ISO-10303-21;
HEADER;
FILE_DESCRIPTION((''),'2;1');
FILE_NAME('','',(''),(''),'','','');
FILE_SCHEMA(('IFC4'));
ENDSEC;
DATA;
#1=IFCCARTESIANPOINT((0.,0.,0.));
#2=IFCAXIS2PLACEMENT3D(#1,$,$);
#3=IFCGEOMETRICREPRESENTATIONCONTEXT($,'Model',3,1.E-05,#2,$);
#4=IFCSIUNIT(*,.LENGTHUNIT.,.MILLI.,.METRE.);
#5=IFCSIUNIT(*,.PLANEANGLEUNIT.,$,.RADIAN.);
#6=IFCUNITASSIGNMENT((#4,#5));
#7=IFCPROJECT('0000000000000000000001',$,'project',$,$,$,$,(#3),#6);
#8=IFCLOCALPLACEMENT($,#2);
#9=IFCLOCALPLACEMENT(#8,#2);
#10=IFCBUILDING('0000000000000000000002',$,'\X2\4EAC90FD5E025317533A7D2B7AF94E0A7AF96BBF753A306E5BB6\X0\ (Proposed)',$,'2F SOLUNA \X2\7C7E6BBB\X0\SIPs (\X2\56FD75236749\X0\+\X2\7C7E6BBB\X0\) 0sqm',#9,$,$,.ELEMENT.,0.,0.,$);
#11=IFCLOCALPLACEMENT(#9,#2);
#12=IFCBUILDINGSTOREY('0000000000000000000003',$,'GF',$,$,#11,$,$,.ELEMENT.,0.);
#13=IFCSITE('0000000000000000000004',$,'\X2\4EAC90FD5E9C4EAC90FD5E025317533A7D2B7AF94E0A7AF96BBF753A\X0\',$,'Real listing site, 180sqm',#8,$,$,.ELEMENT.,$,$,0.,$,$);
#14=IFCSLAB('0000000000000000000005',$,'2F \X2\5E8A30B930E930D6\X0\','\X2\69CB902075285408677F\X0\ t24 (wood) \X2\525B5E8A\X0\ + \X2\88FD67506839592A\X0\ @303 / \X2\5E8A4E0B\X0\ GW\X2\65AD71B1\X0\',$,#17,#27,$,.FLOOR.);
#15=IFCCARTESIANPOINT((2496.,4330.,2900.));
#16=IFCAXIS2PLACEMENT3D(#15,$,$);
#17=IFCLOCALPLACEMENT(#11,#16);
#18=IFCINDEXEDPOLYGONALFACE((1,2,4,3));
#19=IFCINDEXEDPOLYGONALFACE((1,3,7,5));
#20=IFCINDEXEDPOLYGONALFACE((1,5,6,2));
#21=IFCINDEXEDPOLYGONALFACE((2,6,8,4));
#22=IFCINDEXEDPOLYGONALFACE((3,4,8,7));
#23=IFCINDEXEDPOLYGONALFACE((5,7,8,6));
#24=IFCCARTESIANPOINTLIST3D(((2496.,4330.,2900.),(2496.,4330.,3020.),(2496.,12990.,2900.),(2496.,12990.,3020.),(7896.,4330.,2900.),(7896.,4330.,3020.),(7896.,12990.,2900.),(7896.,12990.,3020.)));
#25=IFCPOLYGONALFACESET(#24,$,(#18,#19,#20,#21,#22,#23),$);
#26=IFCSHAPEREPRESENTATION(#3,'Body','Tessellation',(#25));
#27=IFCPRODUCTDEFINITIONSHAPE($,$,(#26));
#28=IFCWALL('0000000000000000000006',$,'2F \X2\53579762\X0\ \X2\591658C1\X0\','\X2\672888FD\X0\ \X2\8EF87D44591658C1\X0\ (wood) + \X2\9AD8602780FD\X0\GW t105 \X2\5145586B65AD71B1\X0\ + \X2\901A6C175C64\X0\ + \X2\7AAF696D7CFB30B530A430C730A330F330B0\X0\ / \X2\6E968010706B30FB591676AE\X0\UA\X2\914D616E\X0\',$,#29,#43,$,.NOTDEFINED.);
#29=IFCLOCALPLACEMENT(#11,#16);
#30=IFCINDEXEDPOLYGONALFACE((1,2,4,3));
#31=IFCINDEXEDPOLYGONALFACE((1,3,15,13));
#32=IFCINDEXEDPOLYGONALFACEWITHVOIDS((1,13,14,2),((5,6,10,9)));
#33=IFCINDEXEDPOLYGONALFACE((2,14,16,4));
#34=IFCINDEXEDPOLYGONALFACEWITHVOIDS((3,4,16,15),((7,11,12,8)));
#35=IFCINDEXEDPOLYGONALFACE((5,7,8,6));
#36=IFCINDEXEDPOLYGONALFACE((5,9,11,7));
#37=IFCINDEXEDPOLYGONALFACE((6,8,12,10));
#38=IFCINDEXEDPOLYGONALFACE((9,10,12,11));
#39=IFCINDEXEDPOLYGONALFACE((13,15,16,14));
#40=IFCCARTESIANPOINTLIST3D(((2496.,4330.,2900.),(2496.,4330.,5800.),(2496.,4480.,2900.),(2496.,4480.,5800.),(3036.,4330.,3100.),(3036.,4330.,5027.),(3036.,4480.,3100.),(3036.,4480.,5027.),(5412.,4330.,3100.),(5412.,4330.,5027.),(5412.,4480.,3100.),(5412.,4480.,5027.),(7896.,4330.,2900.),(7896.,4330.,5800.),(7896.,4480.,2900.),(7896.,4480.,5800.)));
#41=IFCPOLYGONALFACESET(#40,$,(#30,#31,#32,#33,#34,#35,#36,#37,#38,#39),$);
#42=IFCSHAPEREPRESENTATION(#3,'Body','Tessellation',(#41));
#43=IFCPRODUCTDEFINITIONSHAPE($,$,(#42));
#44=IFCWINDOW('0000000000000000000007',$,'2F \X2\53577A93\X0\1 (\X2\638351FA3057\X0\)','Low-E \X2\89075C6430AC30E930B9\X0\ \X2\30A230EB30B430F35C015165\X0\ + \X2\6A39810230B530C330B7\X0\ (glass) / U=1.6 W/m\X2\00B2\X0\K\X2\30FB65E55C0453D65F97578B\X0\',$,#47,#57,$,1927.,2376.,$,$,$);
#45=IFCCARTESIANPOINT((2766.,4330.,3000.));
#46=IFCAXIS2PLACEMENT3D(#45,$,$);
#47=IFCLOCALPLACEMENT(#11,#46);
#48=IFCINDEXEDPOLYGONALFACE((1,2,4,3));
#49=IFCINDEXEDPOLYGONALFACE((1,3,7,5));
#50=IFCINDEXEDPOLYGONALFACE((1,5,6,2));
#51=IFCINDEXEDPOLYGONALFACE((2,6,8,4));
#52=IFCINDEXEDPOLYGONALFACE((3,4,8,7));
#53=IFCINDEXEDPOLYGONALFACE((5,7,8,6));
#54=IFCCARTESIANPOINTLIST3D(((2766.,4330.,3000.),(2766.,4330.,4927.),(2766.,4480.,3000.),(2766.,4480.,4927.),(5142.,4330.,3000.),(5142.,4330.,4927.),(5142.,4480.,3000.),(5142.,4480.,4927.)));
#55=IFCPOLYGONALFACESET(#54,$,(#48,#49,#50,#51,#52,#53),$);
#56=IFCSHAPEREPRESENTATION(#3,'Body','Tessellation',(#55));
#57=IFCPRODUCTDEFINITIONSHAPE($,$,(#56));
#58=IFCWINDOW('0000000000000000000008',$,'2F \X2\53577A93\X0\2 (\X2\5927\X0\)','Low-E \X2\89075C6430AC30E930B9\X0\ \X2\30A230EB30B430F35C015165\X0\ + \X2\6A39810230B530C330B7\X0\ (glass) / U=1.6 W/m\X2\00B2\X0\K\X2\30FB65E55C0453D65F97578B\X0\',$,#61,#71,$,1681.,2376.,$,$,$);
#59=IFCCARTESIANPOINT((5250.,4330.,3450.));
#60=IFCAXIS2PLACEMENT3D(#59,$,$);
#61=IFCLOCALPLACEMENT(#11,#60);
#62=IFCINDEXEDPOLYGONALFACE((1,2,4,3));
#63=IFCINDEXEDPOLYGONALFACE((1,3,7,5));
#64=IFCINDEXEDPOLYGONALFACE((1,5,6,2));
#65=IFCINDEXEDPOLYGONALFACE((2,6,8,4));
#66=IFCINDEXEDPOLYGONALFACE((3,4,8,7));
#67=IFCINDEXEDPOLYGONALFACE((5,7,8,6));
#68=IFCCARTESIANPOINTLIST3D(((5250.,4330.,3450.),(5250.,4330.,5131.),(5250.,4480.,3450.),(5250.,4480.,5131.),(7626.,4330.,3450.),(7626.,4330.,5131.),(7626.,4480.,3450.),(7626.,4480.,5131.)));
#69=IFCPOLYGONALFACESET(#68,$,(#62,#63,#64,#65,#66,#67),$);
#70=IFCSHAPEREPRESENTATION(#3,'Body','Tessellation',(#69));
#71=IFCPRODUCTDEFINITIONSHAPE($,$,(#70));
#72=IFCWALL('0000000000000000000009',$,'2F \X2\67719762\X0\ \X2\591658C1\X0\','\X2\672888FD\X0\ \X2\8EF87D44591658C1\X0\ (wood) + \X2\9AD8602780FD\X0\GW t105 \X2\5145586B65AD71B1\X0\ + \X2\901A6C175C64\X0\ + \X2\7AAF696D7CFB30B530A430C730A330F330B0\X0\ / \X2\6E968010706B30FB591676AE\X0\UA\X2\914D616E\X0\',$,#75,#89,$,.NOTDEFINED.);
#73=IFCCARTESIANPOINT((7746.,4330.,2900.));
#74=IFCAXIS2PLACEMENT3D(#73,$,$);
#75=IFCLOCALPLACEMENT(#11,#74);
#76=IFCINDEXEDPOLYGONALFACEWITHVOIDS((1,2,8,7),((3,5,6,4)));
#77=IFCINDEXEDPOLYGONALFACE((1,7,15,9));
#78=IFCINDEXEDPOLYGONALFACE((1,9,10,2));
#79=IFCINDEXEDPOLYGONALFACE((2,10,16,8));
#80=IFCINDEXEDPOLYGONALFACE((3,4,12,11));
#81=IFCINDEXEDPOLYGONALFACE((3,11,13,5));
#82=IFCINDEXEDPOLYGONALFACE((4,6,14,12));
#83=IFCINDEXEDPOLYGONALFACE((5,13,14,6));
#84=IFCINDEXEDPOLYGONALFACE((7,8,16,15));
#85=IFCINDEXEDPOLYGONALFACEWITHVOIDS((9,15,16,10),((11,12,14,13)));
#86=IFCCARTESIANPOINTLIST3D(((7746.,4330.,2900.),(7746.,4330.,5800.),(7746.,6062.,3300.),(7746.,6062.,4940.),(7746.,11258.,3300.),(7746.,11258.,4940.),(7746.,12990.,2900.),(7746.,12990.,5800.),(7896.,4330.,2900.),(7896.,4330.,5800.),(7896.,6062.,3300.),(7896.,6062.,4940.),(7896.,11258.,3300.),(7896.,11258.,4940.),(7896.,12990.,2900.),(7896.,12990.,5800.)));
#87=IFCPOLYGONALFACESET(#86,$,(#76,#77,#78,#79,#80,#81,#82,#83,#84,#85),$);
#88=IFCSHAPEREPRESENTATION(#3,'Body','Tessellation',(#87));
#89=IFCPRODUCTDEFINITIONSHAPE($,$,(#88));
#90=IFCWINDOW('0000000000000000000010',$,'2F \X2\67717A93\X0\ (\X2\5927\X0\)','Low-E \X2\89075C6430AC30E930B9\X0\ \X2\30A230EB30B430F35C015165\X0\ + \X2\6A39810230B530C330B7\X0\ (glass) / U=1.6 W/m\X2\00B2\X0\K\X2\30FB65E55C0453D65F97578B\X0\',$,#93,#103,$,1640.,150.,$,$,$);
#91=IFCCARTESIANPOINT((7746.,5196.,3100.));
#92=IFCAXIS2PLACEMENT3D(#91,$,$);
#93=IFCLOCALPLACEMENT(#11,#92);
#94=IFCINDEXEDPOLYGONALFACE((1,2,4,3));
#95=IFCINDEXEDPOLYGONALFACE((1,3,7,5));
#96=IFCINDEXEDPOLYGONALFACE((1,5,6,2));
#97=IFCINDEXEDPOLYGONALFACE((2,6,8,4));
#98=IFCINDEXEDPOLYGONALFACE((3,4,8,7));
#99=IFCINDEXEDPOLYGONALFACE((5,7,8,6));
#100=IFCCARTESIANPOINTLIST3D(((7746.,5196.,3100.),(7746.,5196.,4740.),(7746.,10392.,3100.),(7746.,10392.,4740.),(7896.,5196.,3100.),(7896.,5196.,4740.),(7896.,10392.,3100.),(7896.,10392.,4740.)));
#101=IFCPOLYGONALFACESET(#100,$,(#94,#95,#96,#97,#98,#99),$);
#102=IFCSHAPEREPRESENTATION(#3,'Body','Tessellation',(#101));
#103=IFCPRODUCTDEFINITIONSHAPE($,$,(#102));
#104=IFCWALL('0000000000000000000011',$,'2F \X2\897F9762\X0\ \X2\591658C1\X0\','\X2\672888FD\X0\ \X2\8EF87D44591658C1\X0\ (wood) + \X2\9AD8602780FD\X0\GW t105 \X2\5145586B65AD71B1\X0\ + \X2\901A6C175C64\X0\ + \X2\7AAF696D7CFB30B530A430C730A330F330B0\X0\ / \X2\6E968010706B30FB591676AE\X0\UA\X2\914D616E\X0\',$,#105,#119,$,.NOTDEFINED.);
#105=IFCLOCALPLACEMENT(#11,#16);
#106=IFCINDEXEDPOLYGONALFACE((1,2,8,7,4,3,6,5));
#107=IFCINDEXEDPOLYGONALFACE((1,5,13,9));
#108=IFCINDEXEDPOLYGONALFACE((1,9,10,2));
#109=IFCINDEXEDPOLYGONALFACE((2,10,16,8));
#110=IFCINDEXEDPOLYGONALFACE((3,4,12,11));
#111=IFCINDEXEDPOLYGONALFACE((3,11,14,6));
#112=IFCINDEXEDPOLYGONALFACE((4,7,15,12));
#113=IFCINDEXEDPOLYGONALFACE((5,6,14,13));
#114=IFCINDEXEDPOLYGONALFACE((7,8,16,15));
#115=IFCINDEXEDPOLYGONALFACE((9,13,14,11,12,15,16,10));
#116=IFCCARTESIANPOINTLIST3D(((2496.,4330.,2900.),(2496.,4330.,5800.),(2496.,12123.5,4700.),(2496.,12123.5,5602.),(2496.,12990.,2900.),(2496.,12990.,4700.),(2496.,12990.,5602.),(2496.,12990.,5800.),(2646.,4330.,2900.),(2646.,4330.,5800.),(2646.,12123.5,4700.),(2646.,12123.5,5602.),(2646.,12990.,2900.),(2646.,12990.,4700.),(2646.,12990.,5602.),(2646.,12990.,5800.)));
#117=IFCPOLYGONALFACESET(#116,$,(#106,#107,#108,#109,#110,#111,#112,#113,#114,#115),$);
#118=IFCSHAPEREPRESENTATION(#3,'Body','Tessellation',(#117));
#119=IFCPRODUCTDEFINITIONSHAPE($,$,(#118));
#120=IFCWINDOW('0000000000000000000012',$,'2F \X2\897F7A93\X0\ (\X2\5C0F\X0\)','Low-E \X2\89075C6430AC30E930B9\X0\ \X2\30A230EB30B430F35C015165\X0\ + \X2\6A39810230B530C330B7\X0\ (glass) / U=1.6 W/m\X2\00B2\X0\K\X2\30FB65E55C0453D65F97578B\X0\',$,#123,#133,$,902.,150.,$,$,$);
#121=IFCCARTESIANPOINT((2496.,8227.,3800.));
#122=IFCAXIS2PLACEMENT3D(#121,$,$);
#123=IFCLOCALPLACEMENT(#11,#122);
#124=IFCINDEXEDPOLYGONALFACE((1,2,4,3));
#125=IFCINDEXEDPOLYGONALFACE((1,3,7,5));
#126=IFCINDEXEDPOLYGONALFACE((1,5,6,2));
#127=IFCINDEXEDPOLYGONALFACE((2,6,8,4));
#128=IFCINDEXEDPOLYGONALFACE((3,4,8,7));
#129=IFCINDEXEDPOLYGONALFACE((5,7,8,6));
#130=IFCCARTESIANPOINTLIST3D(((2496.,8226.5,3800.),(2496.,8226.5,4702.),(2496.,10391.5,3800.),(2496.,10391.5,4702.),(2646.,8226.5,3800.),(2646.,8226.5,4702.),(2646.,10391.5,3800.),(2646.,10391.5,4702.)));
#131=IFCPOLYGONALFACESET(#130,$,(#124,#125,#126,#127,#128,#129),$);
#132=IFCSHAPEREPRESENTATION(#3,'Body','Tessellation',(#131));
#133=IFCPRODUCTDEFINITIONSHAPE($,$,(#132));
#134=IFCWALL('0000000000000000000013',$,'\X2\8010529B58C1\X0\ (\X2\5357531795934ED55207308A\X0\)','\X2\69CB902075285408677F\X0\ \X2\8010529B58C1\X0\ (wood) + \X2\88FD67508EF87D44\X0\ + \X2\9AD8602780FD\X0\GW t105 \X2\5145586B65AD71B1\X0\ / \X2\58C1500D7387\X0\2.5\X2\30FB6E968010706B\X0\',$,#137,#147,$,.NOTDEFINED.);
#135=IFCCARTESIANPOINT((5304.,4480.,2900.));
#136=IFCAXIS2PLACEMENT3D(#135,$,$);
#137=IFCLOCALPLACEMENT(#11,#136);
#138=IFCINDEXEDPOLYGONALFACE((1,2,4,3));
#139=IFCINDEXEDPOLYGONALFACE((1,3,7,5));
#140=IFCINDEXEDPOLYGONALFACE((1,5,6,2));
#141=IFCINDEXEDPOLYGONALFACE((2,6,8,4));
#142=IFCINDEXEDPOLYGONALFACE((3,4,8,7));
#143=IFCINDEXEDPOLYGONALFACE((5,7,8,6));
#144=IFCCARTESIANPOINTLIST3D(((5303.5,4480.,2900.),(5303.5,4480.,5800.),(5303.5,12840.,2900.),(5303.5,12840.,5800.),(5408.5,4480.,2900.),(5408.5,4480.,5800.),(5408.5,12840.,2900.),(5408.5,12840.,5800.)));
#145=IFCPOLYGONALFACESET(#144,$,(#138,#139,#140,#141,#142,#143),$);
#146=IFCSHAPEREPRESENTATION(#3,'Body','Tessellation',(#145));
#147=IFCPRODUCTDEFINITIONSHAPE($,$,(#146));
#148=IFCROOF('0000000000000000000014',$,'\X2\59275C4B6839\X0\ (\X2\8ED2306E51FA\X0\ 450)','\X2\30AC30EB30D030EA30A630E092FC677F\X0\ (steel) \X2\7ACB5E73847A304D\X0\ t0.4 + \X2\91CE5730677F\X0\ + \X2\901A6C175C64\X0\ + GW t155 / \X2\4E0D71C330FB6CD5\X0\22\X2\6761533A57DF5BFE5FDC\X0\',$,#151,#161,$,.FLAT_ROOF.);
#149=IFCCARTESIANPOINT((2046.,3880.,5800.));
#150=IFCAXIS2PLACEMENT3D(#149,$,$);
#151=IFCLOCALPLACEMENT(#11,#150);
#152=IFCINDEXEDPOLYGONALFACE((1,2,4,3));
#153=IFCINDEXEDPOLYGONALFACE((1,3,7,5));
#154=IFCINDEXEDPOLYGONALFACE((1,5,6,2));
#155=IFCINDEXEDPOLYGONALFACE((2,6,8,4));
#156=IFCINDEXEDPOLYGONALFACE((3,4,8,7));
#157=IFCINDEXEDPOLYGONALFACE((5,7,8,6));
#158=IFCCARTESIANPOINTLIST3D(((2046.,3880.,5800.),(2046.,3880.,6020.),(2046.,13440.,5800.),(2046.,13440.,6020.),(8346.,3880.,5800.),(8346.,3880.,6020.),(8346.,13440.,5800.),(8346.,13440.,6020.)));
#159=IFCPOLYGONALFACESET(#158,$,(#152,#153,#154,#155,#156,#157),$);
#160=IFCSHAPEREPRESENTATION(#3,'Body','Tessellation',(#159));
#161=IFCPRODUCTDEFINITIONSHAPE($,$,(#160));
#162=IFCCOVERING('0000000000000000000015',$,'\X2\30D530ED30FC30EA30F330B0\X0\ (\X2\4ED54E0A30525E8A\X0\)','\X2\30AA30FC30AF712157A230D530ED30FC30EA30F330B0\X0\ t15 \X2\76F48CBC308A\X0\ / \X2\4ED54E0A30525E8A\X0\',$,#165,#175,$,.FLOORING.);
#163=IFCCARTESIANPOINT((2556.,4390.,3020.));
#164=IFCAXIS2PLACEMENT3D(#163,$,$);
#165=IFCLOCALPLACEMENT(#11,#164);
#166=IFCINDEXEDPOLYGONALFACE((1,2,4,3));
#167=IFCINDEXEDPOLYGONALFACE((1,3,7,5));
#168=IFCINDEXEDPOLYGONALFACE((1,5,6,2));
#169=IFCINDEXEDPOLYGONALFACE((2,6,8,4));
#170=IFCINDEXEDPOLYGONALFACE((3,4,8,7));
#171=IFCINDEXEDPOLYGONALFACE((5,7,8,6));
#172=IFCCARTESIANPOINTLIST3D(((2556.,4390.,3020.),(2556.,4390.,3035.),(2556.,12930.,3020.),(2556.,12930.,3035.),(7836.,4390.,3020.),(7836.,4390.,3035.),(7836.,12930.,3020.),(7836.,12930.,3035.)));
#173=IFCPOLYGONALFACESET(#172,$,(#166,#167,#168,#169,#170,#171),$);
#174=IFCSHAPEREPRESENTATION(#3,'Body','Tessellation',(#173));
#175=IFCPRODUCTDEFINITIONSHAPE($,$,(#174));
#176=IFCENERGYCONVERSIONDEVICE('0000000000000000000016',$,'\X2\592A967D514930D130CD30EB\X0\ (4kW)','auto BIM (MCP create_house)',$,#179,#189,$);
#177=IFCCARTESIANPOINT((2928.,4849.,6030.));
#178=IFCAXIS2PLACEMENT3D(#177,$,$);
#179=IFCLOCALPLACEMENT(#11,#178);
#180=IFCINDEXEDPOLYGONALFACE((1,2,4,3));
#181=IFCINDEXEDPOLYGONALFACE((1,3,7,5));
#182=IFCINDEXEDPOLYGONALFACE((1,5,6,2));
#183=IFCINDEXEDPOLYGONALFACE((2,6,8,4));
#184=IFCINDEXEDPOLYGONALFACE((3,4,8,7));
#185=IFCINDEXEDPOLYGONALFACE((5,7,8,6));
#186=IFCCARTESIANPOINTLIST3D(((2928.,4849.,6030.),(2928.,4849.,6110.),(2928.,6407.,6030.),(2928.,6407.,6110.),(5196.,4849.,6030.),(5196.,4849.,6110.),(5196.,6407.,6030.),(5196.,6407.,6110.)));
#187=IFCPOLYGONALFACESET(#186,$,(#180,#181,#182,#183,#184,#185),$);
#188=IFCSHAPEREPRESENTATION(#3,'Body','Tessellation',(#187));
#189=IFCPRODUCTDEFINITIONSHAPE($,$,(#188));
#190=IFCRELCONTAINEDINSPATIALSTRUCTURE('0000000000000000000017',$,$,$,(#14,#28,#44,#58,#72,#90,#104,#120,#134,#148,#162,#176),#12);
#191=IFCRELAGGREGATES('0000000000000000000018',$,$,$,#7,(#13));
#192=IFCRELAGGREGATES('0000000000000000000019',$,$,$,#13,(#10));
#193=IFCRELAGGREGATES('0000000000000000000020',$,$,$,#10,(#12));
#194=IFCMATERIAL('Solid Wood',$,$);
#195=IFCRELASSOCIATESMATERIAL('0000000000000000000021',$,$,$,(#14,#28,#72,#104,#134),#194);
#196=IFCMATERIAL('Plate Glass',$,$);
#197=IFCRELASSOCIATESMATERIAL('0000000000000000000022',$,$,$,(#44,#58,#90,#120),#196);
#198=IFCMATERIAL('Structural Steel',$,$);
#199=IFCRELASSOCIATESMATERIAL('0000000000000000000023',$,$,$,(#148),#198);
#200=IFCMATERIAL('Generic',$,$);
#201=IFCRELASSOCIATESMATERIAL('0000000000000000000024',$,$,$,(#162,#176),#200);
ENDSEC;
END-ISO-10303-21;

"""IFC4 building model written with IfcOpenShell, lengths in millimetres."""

from ifc_helpers import new_model, si_unit, frame, frame_2d, origin, place, context, project, spatial, rectangle, extrude, material, element, fill, save


model = new_model("IFC4")

# Units and contexts
model_context = context("Model", 3, precision=1e-05, world=origin())
ifc_project = project(units=[si_unit("LENGTHUNIT", "METRE", prefix="MILLI"), si_unit("PLANEANGLEUNIT", "RADIAN")], contexts=[model_context])

# Site, building, storey
site_placement = place(None, origin())
site = spatial("IfcSite", under=ifc_project, at=site_placement, Name="京都府京都市北区紫竹上竹殿町", ObjectType="Real listing site, 180sqm", CompositionType="ELEMENT", RefElevation=0.0)
building_placement = place(site_placement, origin())
building = spatial("IfcBuilding", under=site, at=building_placement, Name="京都市北区紫竹上竹殿町の家 (Proposed)", ObjectType="2F SOLUNA 籾殻SIPs (国産杉+籾殻) 0sqm", CompositionType="ELEMENT", ElevationOfRefHeight=0.0, ElevationOfTerrain=0.0)
storey_placement = place(building_placement, origin())
storey = spatial("IfcBuildingStorey", under=building, at=storey_placement, Name="GF", CompositionType="ELEMENT", Elevation=0.0)

# Slab
ifc_material_1 = material(Name="Solid Wood")
slab_placement = place(storey_placement, frame((2496.0, 4330.0, 2900.0)))
element("IfcSlab", 1, at=slab_placement, inside=storey, material=ifc_material_1, Name="2F 床スラブ", Description="構造用合板 t24 (wood) 剛床 + 製材根太 @303 / 床下 GW断熱", PredefinedType="FLOOR", context=model_context, shape_type="SweptSolid", body=[
    extrude(rectangle(XDim=5400.0, YDim=8660.0, at=frame_2d((2700.0, 4330.0))), frame((2496.0, 4330.0, 2900.0)), (0.0, 0.0, 1.0), 120.0),
])

# Wall, openings, windows
wall_1_placement = place(storey_placement, frame((2496.0, 4330.0, 2900.0)))
wall_1 = element("IfcWall", 2, at=wall_1_placement, inside=storey, material=ifc_material_1, Name="2F 南面 外壁", Description="木製 軸組外壁 (wood) + 高性能GW t105 充填断熱 + 通気層 + 窯業系サイディング / 準耐火・外皮UA配慮", PredefinedType="NOTDEFINED", context=model_context, shape_type="SweptSolid", body=[
    extrude(rectangle(XDim=5400.0, YDim=150.0, at=frame_2d((2700.0, 75.0))), frame((2496.0, 4330.0, 2900.0)), (0.0, 0.0, 1.0), 2900.0),
])
opening_1_placement = place(storey_placement, frame((2766.0, 4330.0, 3000.0)))
opening_1 = element("IfcOpeningElement", 3, at=opening_1_placement, cuts=wall_1, PredefinedType="NOTDEFINED", context=model_context, shape_type="SweptSolid", body=[
    extrude(rectangle(XDim=2376.0, YDim=150.0, at=frame_2d((1188.0, 75.0))), frame((2766.0, 4330.0, 3000.0)), (0.0, 0.0, 1.0), 1927.0),
])
opening_2_placement = place(storey_placement, frame((5250.0, 4330.0, 3450.0)))
opening_2 = element("IfcOpeningElement", 4, at=opening_2_placement, cuts=wall_1, PredefinedType="NOTDEFINED", context=model_context, shape_type="SweptSolid", body=[
    extrude(rectangle(XDim=2376.0, YDim=150.0, at=frame_2d((1188.0, 75.0))), frame((5250.0, 4330.0, 3450.0)), (0.0, 0.0, 1.0), 1681.0),
])
ifc_material_2 = material(Name="Plate Glass")
window_1_placement = place(storey_placement, frame((2766.0, 4330.0, 3000.0)))
window_1 = element("IfcWindow", 5, at=window_1_placement, inside=storey, material=ifc_material_2, Name="2F 南窓1 (掃出し)", Description="Low-E 複層ガラス アルゴン封入 + 樹脂サッシ (glass) / U=1.6 W/m²K・日射取得型", OverallHeight=1927.0, OverallWidth=2376.0, context=model_context, shape_type="SweptSolid", body=[
    extrude(rectangle(XDim=2376.0, YDim=150.0, at=frame_2d((1188.0, 75.0))), frame((2766.0, 4330.0, 3000.0)), (0.0, 0.0, 1.0), 1927.0),
])
fill(opening_1, window_1)
window_2_placement = place(storey_placement, frame((5250.0, 4330.0, 3450.0)))
window_2 = element("IfcWindow", 6, at=window_2_placement, inside=storey, material=ifc_material_2, Name="2F 南窓2 (大)", Description="Low-E 複層ガラス アルゴン封入 + 樹脂サッシ (glass) / U=1.6 W/m²K・日射取得型", OverallHeight=1681.0, OverallWidth=2376.0, context=model_context, shape_type="SweptSolid", body=[
    extrude(rectangle(XDim=2376.0, YDim=150.0, at=frame_2d((1188.0, 75.0))), frame((5250.0, 4330.0, 3450.0)), (0.0, 0.0, 1.0), 1681.0),
])
fill(opening_2, window_2)

# Walls, openings, windows
wall_2_placement = place(storey_placement, frame((7746.0, 4330.0, 2900.0)))
wall_2 = element("IfcWall", 7, at=wall_2_placement, inside=storey, material=ifc_material_1, Name="2F 東面 外壁", Description="木製 軸組外壁 (wood) + 高性能GW t105 充填断熱 + 通気層 + 窯業系サイディング / 準耐火・外皮UA配慮", PredefinedType="NOTDEFINED", context=model_context, shape_type="SweptSolid", body=[
    extrude(rectangle(XDim=150.0, YDim=8660.0, at=frame_2d((75.0, 4330.0))), frame((7746.0, 4330.0, 2900.0)), (0.0, 0.0, 1.0), 2900.0),
])
opening_3_placement = place(storey_placement, frame((7746.0, 5196.0, 3100.0)))
opening_3 = element("IfcOpeningElement", 8, at=opening_3_placement, cuts=wall_2, PredefinedType="NOTDEFINED", context=model_context, shape_type="SweptSolid", body=[
    extrude(rectangle(XDim=150.0, YDim=5196.0, at=frame_2d((75.0, 2598.0))), frame((7746.0, 5196.0, 3100.0)), (0.0, 0.0, 1.0), 1640.0),
])
window_3_placement = place(storey_placement, frame((7746.0, 5196.0, 3100.0)))
window_3 = element("IfcWindow", 9, at=window_3_placement, inside=storey, material=ifc_material_2, Name="2F 東窓 (大)", Description="Low-E 複層ガラス アルゴン封入 + 樹脂サッシ (glass) / U=1.6 W/m²K・日射取得型", OverallHeight=1640.0, OverallWidth=150.0, context=model_context, shape_type="SweptSolid", body=[
    extrude(rectangle(XDim=150.0, YDim=5196.0, at=frame_2d((75.0, 2598.0))), frame((7746.0, 5196.0, 3100.0)), (0.0, 0.0, 1.0), 1640.0),
])
fill(opening_3, window_3)
wall_3_placement = place(storey_placement, frame((2496.0, 4330.0, 2900.0)))
wall_3 = element("IfcWall", 10, at=wall_3_placement, inside=storey, material=ifc_material_1, Name="2F 西面 外壁", Description="木製 軸組外壁 (wood) + 高性能GW t105 充填断熱 + 通気層 + 窯業系サイディング / 準耐火・外皮UA配慮", PredefinedType="NOTDEFINED", context=model_context, shape_type="SweptSolid", body=[
    extrude(rectangle(XDim=150.0, YDim=8660.0, at=frame_2d((75.0, 4330.0))), frame((2496.0, 4330.0, 2900.0)), (0.0, 0.0, 1.0), 2900.0),
])
opening_4_placement = place(storey_placement, frame((2496.0, 8227.0, 3800.0)))
opening_4 = element("IfcOpeningElement", 11, at=opening_4_placement, cuts=wall_3, PredefinedType="NOTDEFINED", context=model_context, shape_type="SweptSolid", body=[
    extrude(rectangle(XDim=150.0, YDim=2165.0, at=frame_2d((75.0, 1082.0))), frame((2496.0, 8227.0, 3800.0)), (0.0, 0.0, 1.0), 902.0),
])
window_4_placement = place(storey_placement, frame((2496.0, 8227.0, 3800.0)))
window_4 = element("IfcWindow", 12, at=window_4_placement, inside=storey, material=ifc_material_2, Name="2F 西窓 (小)", Description="Low-E 複層ガラス アルゴン封入 + 樹脂サッシ (glass) / U=1.6 W/m²K・日射取得型", OverallHeight=902.0, OverallWidth=150.0, context=model_context, shape_type="SweptSolid", body=[
    extrude(rectangle(XDim=150.0, YDim=2165.0, at=frame_2d((75.0, 1082.0))), frame((2496.0, 8227.0, 3800.0)), (0.0, 0.0, 1.0), 902.0),
])
fill(opening_4, window_4)

# Wall
wall_4_placement = place(storey_placement, frame((5304.0, 4480.0, 2900.0)))
element("IfcWall", 13, at=wall_4_placement, inside=storey, material=ifc_material_1, Name="耐力壁 (南北間仕切り)", Description="構造用合板 耐力壁 (wood) + 製材軸組 + 高性能GW t105 充填断熱 / 壁倍率2.5・準耐火", PredefinedType="NOTDEFINED", context=model_context, shape_type="SweptSolid", body=[
    extrude(rectangle(XDim=105.0, YDim=8360.0, at=frame_2d((52.0, 4180.0))), frame((5304.0, 4480.0, 2900.0)), (0.0, 0.0, 1.0), 2900.0),
])

# Roof
ifc_material_3 = material(Name="Structural Steel")
roof_placement = place(storey_placement, frame((2046.0, 3880.0, 5800.0)))
element("IfcRoof", 14, at=roof_placement, inside=storey, material=ifc_material_3, Name="大屋根 (軒の出 450)", Description="ガルバリウム鋼板 (steel) 立平葺き t0.4 + 野地板 + 通気層 + GW t155 / 不燃・法22条区域対応", PredefinedType="FLAT_ROOF", context=model_context, shape_type="SweptSolid", body=[
    extrude(rectangle(XDim=6300.0, YDim=9560.0, at=frame_2d((3150.0, 4780.0))), frame((2046.0, 3880.0, 5800.0)), (0.0, 0.0, 1.0), 220.0),
])

# Covering
ifc_material_4 = material(Name="Generic")
covering_placement = place(storey_placement, frame((2556.0, 4390.0, 3020.0)))
element("IfcCovering", 15, at=covering_placement, inside=storey, material=ifc_material_4, Name="フローリング (仕上げ床)", Description="オーク無垢フローリング t15 直貼り / 仕上げ床", PredefinedType="FLOORING", context=model_context, shape_type="SweptSolid", body=[
    extrude(rectangle(XDim=5280.0, YDim=8540.0, at=frame_2d((2640.0, 4270.0))), frame((2556.0, 4390.0, 3020.0)), (0.0, 0.0, 1.0), 15.0),
])

# Energy conversion device
energy_conversion_device_placement = place(storey_placement, frame((2928.0, 4849.0, 6030.0)))
element("IfcEnergyConversionDevice", 16, at=energy_conversion_device_placement, inside=storey, material=ifc_material_4, Name="太陽光パネル (4kW)", Description="auto BIM (MCP create_house)", context=model_context, shape_type="SweptSolid", body=[
    extrude(rectangle(XDim=2268.0, YDim=1558.0, at=frame_2d((1134.0, 779.0))), frame((2928.0, 4849.0, 6030.0)), (0.0, 0.0, 1.0), 80.0),
])

save(model, "model.ifc")
